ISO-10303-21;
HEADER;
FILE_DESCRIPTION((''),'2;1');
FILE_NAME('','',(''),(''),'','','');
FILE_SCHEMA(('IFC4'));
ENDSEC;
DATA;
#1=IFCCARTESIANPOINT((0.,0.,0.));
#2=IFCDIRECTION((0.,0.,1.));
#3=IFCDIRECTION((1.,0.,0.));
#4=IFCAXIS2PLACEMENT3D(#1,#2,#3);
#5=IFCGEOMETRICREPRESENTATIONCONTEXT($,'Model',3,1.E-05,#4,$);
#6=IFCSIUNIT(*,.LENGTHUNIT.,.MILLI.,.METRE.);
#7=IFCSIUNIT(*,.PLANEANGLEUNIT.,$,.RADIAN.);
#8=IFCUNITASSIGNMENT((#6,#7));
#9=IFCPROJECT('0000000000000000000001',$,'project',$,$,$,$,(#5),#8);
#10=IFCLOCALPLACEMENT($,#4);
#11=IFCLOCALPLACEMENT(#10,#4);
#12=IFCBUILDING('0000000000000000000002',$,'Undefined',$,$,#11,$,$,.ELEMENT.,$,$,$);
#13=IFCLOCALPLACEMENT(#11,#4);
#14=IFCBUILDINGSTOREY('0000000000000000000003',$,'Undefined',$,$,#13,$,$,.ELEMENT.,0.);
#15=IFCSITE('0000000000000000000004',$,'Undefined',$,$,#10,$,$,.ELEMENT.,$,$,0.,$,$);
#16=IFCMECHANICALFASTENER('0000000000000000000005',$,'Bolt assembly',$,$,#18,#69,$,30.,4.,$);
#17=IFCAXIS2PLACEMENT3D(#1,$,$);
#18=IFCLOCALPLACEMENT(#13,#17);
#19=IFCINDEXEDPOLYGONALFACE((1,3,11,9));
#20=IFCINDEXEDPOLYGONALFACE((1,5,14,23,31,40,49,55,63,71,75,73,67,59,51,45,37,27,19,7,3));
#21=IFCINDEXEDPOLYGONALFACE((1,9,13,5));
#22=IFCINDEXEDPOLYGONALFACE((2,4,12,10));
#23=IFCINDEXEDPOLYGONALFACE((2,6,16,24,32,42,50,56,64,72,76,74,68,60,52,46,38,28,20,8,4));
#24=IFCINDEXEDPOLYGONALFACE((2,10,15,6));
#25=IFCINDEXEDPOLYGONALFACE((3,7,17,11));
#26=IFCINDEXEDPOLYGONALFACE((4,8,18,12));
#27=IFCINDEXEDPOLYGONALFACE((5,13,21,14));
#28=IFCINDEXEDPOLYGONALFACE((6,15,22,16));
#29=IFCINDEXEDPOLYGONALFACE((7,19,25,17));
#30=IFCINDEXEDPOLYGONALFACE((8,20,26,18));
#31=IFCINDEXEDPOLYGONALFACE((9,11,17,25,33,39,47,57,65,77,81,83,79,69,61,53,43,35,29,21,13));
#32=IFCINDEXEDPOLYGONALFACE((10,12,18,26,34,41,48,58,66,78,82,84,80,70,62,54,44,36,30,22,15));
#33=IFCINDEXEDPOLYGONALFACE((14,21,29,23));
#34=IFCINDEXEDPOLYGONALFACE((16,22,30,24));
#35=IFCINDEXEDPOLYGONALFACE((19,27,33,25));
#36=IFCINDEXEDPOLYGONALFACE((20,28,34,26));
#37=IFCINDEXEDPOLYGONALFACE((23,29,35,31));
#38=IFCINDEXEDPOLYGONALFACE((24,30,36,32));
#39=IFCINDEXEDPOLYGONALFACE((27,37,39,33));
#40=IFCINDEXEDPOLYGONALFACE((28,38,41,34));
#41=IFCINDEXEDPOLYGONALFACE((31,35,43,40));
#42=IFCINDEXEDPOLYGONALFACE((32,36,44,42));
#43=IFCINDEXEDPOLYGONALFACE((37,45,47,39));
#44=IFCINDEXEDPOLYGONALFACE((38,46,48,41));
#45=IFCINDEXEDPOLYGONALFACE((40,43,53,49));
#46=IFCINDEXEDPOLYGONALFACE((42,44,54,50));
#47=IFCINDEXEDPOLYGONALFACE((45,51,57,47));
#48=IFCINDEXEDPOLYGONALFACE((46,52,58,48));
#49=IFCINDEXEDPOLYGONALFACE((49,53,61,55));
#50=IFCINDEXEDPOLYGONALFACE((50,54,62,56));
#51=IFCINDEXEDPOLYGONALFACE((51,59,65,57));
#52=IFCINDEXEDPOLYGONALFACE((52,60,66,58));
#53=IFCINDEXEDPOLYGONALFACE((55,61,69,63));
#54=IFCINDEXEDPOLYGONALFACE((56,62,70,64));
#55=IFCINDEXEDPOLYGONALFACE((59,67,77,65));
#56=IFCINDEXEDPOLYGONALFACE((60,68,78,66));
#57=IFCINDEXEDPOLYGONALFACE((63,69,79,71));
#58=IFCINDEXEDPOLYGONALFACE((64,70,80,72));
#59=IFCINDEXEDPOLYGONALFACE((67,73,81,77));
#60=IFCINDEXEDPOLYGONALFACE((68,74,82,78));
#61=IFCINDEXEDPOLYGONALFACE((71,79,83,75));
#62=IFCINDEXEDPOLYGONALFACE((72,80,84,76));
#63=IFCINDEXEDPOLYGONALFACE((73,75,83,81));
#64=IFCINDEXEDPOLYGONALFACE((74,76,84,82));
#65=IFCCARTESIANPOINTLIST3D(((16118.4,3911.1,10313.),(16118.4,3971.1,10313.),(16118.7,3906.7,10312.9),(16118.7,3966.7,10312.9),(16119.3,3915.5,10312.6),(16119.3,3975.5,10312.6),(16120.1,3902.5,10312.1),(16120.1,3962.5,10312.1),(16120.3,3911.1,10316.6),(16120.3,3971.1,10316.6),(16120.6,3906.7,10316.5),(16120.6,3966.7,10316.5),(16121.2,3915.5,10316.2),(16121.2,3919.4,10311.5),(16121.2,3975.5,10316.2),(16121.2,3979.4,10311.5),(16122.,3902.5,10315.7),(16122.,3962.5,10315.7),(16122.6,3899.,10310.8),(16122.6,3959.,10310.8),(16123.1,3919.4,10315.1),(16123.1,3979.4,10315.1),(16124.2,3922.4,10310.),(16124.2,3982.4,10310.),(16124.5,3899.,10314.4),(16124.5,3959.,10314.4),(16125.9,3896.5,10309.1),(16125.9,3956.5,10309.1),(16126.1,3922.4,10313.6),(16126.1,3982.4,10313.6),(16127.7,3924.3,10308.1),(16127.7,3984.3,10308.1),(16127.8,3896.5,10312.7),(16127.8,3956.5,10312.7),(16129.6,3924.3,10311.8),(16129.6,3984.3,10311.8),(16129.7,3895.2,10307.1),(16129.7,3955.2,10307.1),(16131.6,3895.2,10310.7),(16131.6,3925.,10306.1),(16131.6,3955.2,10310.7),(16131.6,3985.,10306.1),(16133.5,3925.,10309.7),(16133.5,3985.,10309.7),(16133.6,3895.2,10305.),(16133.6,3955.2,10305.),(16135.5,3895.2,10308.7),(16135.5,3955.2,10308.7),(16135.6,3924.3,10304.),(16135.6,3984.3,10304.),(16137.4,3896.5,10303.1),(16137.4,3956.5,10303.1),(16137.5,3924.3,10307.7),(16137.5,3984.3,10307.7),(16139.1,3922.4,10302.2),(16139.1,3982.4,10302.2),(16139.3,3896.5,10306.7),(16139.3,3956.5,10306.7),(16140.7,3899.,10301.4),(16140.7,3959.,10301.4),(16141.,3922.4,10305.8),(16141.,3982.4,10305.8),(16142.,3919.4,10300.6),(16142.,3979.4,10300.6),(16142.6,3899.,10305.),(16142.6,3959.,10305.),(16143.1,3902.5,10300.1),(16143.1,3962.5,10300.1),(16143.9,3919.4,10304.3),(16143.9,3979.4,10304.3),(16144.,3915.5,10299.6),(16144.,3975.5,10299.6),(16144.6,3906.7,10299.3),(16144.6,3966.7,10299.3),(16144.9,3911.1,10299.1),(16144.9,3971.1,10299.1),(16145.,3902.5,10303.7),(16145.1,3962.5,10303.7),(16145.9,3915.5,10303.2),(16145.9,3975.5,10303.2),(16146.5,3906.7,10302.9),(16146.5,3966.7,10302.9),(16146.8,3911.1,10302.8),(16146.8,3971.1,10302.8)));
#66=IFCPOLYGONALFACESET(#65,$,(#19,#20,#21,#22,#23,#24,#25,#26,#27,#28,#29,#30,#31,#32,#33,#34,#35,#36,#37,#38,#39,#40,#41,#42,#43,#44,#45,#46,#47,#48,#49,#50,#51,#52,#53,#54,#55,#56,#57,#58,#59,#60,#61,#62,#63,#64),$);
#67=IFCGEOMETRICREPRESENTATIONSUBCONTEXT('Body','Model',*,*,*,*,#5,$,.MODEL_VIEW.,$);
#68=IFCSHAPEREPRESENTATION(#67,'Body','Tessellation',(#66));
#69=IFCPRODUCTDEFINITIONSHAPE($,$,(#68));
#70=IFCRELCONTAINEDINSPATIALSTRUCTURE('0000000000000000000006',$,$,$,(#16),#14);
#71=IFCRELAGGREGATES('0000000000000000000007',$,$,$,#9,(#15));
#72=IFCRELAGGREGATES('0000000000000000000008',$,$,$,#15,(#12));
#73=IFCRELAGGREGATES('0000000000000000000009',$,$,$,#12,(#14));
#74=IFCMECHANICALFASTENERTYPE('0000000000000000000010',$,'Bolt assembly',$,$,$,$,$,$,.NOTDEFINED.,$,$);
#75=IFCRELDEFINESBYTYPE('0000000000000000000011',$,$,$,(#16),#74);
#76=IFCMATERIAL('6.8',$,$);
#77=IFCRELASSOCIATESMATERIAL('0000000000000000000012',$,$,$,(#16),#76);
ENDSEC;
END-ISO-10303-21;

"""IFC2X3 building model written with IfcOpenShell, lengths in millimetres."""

from ifc_helpers import new_model, si_unit, frame, origin_with_axes, origin_2d_with_axis, place, context, subcontext, project, spatial, circle, extrude, source, transform, mapped, material, type_object, element, save


model = new_model("IFC2X3")

# Units and contexts
model_context = context("Model", 3, precision=1e-05, world=origin_with_axes())
body_context = subcontext(model_context, "Body", "Model", "MODEL_VIEW")
ifc_project = project(units=[si_unit("LENGTHUNIT", "METRE", prefix="MILLI"), si_unit("PLANEANGLEUNIT", "RADIAN")], contexts=[model_context])

# Site, building, storey
site_placement = place(None, origin_with_axes())
site = spatial("IfcSite", under=ifc_project, at=site_placement, Name="Undefined", CompositionType="ELEMENT", RefElevation=0.0)
building_placement = place(site_placement, origin_with_axes())
building = spatial("IfcBuilding", under=site, at=building_placement, Name="Undefined", CompositionType="ELEMENT")
storey_placement = place(building_placement, origin_with_axes())
storey = spatial("IfcBuildingStorey", under=building, at=storey_placement, Name="Undefined", CompositionType="ELEMENT", Elevation=0.0)

# Mechanical fastener
mechanical_fastener_type = type_object("IfcMechanicalFastenerType", Name="Bolt assembly")
ifc_material_1 = material(Name="6.8")
shared_shape_1 = source(origin_with_axes(), body_context, "Body", "SweptSolid", [
    extrude(circle(Radius=15.0, at=origin_2d_with_axis()), frame((0.0, 0.0, 0.0), z_axis=(0.0, 1.0, 0.0), x_axis=(1.0, 0.0, 0.0)), (0.0, 0.0, 1.0), 4.1),
])
mechanical_fastener_1_placement = place(storey_placement, frame((16133.5, 3910.0, 10309.7), z_axis=(-0.886082, 0.000023, 0.463528), x_axis=(0.00002, 1.0, -0.00001)))
element("IfcMechanicalFastener", 1, at=mechanical_fastener_1_placement, inside=storey, type_object=mechanical_fastener_type, material=ifc_material_1, Name="Bolt assembly", NominalDiameter=30.0, NominalLength=4.0, context=body_context, shape_type="MappedRepresentation", body=[
    mapped(shared_shape_1, transform((0.0, 0.0, 0.0))),
    mapped(shared_shape_1, transform((60.0, 0.0, 0.0))),
])

save(model, "model.ifc")
